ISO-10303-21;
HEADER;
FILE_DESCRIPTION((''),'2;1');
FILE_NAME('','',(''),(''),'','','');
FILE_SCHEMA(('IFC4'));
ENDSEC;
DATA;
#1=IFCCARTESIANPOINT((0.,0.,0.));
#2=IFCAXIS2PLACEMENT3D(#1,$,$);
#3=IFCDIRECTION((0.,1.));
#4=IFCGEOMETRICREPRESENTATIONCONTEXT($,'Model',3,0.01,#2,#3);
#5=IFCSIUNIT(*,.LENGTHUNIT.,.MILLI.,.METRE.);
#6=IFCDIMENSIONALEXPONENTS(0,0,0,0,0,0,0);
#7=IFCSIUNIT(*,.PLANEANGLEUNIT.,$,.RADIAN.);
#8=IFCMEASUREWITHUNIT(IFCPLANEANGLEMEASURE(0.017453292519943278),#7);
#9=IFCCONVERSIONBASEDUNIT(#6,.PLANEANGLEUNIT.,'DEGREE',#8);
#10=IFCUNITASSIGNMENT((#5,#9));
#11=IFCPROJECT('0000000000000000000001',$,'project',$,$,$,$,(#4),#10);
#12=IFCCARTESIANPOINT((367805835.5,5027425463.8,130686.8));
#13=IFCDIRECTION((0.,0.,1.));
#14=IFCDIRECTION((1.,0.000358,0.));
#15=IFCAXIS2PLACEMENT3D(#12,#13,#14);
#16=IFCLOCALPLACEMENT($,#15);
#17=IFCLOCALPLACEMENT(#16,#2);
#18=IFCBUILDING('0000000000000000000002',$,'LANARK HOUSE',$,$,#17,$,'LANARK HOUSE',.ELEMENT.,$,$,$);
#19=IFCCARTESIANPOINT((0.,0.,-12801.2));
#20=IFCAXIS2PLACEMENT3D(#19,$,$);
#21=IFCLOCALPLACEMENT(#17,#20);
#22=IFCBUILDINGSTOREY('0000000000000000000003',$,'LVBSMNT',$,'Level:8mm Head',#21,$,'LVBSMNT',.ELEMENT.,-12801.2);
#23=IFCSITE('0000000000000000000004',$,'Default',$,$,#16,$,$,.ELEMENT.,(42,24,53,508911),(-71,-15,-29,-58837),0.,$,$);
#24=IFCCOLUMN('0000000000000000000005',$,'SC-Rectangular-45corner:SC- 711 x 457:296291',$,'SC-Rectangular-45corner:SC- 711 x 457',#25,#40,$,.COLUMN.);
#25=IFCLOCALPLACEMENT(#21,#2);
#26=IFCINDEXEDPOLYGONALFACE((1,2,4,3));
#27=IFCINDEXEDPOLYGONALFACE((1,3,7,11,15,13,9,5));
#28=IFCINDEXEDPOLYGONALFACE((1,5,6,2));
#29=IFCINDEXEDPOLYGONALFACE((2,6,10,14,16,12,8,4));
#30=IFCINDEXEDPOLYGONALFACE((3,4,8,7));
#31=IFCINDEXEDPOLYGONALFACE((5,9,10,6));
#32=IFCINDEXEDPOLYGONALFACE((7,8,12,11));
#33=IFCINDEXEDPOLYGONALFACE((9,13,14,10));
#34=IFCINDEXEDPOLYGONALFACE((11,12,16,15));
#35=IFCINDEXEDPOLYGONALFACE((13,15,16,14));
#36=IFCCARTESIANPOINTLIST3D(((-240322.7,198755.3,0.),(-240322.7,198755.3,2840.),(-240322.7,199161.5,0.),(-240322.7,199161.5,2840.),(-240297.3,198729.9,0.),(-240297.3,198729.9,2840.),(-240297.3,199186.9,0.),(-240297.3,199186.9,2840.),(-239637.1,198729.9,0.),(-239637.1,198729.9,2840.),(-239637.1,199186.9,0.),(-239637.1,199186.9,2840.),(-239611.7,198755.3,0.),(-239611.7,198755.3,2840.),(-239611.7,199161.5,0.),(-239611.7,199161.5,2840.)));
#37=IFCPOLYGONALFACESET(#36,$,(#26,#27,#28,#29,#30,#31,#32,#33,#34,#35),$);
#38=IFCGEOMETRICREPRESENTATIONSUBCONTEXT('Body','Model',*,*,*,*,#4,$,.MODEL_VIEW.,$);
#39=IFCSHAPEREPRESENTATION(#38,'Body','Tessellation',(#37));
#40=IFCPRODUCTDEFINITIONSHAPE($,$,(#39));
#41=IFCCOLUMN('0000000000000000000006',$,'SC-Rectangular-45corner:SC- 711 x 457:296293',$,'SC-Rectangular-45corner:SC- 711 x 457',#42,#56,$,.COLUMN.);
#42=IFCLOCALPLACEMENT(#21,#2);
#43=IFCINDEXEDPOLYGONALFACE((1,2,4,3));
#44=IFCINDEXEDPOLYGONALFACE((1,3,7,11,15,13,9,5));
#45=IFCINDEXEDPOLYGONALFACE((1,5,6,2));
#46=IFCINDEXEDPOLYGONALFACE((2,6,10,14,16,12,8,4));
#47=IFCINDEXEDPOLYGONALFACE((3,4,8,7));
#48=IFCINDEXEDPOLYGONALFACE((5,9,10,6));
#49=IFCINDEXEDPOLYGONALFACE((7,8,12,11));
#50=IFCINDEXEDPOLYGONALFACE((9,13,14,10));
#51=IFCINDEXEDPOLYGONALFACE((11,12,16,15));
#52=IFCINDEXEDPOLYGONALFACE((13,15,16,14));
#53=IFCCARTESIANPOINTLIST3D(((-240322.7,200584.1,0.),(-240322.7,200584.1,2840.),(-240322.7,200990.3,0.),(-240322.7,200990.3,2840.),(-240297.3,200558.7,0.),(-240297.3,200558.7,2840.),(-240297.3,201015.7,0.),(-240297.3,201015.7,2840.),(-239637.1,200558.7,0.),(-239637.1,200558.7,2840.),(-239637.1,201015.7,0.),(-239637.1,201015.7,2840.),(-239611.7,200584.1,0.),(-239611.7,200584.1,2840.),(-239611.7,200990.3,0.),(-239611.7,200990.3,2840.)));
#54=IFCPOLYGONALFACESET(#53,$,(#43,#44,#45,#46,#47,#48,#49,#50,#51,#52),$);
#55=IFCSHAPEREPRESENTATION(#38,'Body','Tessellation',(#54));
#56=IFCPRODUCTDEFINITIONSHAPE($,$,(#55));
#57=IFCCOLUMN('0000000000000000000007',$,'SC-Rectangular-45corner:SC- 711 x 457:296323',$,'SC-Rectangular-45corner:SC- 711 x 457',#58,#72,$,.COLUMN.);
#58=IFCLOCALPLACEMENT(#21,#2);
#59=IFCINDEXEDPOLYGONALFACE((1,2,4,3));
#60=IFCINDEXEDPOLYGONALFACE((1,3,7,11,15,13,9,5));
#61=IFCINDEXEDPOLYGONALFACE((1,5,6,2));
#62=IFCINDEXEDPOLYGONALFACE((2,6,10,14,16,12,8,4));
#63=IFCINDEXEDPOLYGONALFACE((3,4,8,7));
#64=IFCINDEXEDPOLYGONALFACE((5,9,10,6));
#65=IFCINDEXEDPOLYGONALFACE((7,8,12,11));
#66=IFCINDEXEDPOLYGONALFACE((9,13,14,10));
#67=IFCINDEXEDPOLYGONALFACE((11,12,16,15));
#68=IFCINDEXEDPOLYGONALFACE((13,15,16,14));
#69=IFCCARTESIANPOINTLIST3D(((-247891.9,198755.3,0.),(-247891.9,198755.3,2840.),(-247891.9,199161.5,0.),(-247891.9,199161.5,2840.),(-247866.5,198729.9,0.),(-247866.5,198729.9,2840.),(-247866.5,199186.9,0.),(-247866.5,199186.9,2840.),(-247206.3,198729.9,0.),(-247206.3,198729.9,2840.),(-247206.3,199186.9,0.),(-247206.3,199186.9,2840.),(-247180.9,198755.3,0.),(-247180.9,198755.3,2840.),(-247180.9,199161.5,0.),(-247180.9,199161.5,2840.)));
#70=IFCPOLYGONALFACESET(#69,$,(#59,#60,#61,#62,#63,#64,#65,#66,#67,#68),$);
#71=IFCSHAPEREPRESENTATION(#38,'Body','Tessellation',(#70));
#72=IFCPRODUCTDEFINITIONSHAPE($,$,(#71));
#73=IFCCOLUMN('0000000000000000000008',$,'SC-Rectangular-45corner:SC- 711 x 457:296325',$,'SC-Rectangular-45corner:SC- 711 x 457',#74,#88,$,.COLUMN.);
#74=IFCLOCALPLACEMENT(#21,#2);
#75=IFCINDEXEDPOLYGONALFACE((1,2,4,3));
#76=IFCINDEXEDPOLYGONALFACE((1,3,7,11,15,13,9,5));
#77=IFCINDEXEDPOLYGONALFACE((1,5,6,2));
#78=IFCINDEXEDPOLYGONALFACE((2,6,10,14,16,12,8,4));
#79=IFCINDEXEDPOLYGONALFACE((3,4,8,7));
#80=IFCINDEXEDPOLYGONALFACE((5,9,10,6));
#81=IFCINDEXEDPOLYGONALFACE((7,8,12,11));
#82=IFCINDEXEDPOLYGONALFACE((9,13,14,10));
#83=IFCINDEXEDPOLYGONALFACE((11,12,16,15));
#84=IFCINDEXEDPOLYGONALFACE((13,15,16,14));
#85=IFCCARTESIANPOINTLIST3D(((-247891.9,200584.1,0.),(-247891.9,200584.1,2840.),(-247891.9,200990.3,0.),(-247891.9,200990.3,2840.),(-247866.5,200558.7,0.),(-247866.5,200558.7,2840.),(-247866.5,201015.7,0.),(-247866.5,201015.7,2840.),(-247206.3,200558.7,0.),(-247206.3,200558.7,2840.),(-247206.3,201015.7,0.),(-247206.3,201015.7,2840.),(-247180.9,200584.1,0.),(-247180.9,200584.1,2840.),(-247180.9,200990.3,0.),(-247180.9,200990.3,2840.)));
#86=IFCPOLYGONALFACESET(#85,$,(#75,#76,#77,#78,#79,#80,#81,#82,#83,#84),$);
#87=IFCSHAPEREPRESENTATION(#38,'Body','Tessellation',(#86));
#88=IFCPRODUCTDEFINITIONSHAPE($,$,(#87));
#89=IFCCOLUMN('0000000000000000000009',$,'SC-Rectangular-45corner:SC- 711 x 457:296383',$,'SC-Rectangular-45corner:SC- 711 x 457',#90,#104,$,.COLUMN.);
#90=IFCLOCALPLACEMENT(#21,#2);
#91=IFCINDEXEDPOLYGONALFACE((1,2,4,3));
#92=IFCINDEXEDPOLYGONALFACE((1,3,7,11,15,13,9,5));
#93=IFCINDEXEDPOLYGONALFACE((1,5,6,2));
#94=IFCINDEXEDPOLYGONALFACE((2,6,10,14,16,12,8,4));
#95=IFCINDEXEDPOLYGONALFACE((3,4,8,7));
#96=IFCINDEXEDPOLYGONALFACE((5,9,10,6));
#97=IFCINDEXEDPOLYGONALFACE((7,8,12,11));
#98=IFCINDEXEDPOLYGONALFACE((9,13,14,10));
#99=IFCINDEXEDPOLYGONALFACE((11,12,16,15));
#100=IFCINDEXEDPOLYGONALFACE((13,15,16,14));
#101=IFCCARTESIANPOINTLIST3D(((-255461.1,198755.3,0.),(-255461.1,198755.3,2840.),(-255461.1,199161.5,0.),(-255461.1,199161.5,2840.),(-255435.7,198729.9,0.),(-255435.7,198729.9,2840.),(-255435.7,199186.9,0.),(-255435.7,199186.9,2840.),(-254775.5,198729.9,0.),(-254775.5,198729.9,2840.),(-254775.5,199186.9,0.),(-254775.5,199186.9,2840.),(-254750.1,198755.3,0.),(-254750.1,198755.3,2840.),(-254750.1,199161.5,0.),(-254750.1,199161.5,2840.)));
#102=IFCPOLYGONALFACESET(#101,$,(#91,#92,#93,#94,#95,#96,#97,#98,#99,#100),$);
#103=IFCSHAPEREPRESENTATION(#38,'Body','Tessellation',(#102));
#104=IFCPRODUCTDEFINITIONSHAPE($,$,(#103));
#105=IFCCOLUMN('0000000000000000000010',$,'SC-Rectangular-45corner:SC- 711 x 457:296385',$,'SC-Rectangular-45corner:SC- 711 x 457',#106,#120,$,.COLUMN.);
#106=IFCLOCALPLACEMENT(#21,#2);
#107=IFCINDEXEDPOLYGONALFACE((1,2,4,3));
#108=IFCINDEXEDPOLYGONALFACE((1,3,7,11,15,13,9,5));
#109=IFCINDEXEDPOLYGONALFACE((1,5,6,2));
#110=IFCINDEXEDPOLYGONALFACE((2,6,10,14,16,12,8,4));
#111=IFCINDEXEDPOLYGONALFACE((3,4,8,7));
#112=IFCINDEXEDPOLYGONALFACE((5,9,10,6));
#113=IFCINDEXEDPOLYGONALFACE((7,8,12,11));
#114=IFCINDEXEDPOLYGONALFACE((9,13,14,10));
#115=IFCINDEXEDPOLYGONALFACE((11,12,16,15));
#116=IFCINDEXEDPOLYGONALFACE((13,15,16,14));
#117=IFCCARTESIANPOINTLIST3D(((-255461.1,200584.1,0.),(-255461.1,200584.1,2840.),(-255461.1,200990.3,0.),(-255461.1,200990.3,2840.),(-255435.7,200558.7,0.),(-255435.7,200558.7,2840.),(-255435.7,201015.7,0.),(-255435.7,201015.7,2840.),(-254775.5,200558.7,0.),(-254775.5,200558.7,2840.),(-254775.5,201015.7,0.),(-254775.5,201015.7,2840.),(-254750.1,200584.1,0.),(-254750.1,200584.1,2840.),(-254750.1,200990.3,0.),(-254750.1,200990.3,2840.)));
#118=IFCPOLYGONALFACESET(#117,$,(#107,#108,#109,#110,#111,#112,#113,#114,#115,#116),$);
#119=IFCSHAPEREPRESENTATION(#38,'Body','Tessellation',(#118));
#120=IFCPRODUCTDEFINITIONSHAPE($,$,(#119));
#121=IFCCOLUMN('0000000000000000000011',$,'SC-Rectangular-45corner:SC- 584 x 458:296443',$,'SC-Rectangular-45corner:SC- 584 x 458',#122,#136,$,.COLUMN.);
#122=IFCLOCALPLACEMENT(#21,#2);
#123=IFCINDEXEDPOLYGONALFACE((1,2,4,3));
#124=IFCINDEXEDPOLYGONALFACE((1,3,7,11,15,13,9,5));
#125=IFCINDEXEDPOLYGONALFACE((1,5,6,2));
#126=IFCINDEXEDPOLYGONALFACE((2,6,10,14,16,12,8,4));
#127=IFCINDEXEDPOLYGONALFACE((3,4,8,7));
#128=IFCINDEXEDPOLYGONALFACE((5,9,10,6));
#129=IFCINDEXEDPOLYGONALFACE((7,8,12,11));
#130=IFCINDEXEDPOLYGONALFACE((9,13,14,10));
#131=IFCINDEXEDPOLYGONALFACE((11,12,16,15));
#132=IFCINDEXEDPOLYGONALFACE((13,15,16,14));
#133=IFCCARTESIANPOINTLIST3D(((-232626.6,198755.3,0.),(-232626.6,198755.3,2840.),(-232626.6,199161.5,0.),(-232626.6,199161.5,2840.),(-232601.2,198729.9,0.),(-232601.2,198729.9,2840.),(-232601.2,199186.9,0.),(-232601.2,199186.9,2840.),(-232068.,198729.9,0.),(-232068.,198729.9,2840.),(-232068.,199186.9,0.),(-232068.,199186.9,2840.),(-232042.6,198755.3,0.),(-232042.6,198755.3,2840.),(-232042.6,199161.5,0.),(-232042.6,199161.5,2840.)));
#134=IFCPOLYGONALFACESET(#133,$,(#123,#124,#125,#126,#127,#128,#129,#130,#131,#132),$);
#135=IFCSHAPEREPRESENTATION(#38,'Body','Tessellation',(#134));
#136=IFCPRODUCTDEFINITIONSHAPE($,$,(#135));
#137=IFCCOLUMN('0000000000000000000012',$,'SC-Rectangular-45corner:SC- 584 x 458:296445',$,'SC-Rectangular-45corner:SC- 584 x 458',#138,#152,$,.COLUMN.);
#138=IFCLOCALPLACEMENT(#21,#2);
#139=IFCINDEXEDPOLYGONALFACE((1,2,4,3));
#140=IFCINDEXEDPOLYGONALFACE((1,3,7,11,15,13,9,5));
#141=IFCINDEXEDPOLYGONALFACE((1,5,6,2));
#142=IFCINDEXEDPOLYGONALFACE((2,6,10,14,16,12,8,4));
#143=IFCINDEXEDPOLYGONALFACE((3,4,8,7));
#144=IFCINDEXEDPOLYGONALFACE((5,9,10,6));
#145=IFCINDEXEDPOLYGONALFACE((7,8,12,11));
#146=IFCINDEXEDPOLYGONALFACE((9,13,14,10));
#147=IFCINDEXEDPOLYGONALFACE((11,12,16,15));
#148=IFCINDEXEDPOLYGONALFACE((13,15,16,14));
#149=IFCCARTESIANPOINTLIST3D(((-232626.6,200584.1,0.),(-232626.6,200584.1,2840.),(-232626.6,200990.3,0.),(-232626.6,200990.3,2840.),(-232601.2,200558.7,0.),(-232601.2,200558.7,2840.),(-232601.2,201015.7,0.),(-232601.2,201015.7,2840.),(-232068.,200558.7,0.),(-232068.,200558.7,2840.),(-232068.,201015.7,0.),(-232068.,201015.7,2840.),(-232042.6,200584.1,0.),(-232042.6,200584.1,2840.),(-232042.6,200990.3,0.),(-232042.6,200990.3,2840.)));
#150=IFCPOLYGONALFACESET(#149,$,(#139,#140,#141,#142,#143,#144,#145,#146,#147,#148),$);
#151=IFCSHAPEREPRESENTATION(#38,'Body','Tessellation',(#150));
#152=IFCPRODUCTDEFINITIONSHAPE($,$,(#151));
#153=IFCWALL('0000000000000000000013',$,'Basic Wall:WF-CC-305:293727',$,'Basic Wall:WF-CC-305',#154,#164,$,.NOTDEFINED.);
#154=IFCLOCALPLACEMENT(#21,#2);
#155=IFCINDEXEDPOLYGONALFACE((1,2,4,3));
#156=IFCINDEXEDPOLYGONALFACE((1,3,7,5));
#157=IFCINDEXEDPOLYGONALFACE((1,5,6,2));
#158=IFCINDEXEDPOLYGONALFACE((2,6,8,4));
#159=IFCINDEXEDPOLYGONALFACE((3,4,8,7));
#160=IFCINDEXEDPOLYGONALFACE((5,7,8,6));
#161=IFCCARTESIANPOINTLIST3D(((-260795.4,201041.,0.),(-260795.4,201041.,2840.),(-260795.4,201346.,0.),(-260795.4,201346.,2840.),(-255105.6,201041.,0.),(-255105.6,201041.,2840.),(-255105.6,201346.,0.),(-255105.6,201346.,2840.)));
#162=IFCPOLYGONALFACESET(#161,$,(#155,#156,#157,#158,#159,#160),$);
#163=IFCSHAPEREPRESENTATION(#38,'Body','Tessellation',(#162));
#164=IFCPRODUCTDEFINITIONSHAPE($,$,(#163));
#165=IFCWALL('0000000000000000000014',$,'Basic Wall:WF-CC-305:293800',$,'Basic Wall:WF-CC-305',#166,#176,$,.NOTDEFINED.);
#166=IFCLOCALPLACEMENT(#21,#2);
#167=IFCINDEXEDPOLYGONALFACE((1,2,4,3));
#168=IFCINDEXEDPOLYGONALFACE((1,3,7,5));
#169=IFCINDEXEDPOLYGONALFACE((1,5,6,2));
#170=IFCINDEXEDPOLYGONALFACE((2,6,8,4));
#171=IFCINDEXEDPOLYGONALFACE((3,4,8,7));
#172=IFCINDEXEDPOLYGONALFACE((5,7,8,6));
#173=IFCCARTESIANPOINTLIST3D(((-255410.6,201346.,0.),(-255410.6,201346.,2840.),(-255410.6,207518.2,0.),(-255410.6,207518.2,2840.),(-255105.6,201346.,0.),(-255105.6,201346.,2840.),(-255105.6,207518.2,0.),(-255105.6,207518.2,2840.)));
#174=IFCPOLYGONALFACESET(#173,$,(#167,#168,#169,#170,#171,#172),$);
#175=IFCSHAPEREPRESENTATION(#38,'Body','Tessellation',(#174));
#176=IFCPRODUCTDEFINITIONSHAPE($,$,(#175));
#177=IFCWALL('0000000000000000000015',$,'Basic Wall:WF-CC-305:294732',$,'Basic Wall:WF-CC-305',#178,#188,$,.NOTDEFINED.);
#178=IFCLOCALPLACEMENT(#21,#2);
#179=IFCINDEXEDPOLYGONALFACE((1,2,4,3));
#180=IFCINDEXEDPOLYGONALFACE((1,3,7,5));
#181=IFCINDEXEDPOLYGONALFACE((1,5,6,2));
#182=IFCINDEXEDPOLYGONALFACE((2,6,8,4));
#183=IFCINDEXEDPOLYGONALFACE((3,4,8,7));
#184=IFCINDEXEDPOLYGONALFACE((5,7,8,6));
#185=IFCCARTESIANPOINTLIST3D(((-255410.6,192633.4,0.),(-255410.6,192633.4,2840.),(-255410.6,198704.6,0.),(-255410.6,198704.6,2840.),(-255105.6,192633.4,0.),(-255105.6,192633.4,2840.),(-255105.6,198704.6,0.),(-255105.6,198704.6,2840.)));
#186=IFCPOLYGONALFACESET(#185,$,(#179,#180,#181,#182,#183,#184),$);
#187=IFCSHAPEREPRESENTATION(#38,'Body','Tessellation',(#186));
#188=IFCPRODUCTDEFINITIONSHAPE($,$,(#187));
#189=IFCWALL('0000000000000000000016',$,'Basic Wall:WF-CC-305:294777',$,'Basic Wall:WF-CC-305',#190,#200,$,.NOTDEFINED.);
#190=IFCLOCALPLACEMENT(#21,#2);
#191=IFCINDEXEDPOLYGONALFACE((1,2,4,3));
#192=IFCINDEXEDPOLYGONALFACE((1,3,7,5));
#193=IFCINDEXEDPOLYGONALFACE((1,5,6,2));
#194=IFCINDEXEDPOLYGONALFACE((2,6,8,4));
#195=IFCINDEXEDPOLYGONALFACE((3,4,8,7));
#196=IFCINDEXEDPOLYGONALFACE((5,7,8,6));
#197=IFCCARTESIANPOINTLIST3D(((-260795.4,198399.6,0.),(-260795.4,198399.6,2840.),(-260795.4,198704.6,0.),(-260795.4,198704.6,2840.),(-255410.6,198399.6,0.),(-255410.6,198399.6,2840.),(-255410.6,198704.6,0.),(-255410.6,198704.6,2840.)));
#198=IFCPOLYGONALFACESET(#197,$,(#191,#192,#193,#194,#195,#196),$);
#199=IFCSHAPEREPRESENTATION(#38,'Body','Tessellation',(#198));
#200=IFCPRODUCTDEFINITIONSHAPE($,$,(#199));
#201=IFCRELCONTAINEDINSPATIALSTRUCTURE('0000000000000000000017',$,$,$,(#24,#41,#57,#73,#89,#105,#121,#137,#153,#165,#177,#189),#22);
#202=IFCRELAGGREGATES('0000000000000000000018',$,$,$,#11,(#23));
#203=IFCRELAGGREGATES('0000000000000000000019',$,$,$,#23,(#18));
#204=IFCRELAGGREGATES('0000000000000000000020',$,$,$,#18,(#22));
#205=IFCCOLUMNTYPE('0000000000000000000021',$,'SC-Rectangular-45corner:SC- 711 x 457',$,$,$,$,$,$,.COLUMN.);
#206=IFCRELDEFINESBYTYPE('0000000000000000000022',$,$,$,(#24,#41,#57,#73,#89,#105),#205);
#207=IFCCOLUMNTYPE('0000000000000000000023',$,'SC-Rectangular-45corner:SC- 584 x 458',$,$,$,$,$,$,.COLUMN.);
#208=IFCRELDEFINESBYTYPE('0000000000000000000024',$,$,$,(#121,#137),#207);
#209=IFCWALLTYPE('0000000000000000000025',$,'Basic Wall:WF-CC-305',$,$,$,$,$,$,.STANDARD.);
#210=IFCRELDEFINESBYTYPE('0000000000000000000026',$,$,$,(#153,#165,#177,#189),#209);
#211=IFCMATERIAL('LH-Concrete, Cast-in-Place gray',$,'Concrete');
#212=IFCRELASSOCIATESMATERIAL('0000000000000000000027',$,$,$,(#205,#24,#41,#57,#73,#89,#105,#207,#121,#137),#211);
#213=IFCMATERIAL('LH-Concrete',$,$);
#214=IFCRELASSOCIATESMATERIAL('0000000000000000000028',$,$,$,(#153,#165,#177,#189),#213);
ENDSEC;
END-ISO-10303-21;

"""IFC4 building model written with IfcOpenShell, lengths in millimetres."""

from ifc_helpers import new_model, entity, si_unit, converted_unit, direction, frame, origin, place, context, subcontext, project, spatial, indexed_curve, outline, extrude, source, transform, mapped, material, type_object, type_shapes, element, save


model = new_model("IFC4")

# Units and contexts
model_context = context("Model", 3, precision=0.01, world=origin(), true_north=direction((0.0, 1.0)))
body_context = subcontext(model_context, "Body", "Model", "MODEL_VIEW")
ifc_project = project(units=[si_unit("LENGTHUNIT", "METRE", prefix="MILLI"), converted_unit("PLANEANGLEUNIT", "DEGREE", entity("IfcPlaneAngleMeasure", 0.017453292519943278), si_unit("PLANEANGLEUNIT", "RADIAN"), dimensions=[0, 0, 0, 0, 0, 0, 0])], contexts=[model_context])

# Site, building, storey
site_placement = place(None, frame((367805835.5, 5027425463.8, 130686.8), z_axis=(0.0, 0.0, 1.0), x_axis=(1.0, 0.000358, 0.0)))
site = spatial("IfcSite", under=ifc_project, at=site_placement, Name="Default", CompositionType="ELEMENT", RefLatitude=(42, 24, 53, 508911), RefLongitude=(-71, -15, -29, -58837), RefElevation=0.0)
building_placement = place(site_placement, origin())
building = spatial("IfcBuilding", under=site, at=building_placement, Name="LANARK HOUSE", LongName="LANARK HOUSE", CompositionType="ELEMENT")
storey_placement = place(building_placement, frame((0.0, 0.0, -12801.2)))
storey = spatial("IfcBuildingStorey", under=building, at=storey_placement, Name="LVBSMNT", ObjectType="Level:8mm Head", LongName="LVBSMNT", CompositionType="ELEMENT", Elevation=-12801.2)

# Columns
ifc_material_1 = material(Name="LH-Concrete, Cast-in-Place gray", Category="Concrete")
column_type_1 = type_object("IfcColumnType", Name="SC-Rectangular-45corner:SC- 711 x 457", PredefinedType="COLUMN", material=ifc_material_1)
shared_shape_1 = source(origin(), body_context, "Body", "SweptSolid", [
    extrude(outline(indexed_curve([(-330.1, -228.5), (330.1, -228.5), (355.5, -203.1), (355.5, 203.1), (330.1, 228.5), (-330.1, 228.5), (-355.5, 203.1), (-355.5, -203.1), (-330.1, -228.5)], self_intersect=False)), frame((0.0, 0.0, -12801.2), z_axis=(0.0, 0.0, 1.0), x_axis=(-1.0, 0.0, 0.0)), (0.0, 0.0, 1.0), 2840.0),
])
type_shapes(column_type_1, [shared_shape_1])
for number, where, name in (
    (1, (-239967.2, 198958.4, 12801.2), "SC-Rectangular-45corner:SC- 711 x 457:296291"),
    (2, (-239967.2, 200787.2, 12801.2), "SC-Rectangular-45corner:SC- 711 x 457:296293"),
    (3, (-247536.4, 198958.4, 12801.2), "SC-Rectangular-45corner:SC- 711 x 457:296323"),
    (4, (-247536.4, 200787.2, 12801.2), "SC-Rectangular-45corner:SC- 711 x 457:296325"),
    (5, (-255105.6, 198958.4, 12801.2), "SC-Rectangular-45corner:SC- 711 x 457:296383"),
    (6, (-255105.6, 200787.2, 12801.2), "SC-Rectangular-45corner:SC- 711 x 457:296385"),
):
    element("IfcColumn", number, at=place(storey_placement, frame(where)), inside=storey, type_object=column_type_1, material=ifc_material_1, Name=name, ObjectType="SC-Rectangular-45corner:SC- 711 x 457", PredefinedType="COLUMN", context=body_context, shape_type="MappedRepresentation", body=[
        mapped(shared_shape_1, transform((0.0, 0.0, 0.0), scale=1.0)),
    ])
column_type_2 = type_object("IfcColumnType", Name="SC-Rectangular-45corner:SC- 584 x 458", PredefinedType="COLUMN", material=ifc_material_1)
shared_shape_2 = source(origin(), body_context, "Body", "SweptSolid", [
    extrude(outline(indexed_curve([(-266.6, -228.5), (266.6, -228.5), (292.0, -203.1), (292.0, 203.1), (266.6, 228.5), (-266.6, 228.5), (-292.0, 203.1), (-292.0, -203.1), (-266.6, -228.5)], self_intersect=False)), frame((0.0, 0.0, -12801.2), z_axis=(0.0, 0.0, 1.0), x_axis=(-1.0, 0.0, 0.0)), (0.0, 0.0, 1.0), 2840.0),
])
type_shapes(column_type_2, [shared_shape_2])
for number, where, name in (
    (7, (-232334.6, 198958.4, 12801.2), "SC-Rectangular-45corner:SC- 584 x 458:296443"),
    (8, (-232334.6, 200787.2, 12801.2), "SC-Rectangular-45corner:SC- 584 x 458:296445"),
):
    element("IfcColumn", number, at=place(storey_placement, frame(where)), inside=storey, type_object=column_type_2, material=ifc_material_1, Name=name, ObjectType="SC-Rectangular-45corner:SC- 584 x 458", PredefinedType="COLUMN", context=body_context, shape_type="MappedRepresentation", body=[
        mapped(shared_shape_2, transform((0.0, 0.0, 0.0), scale=1.0)),
    ])

# Walls
ifc_material_2 = material(Name="LH-Concrete")
wall_type_1 = type_object("IfcWallType", Name="Basic Wall:WF-CC-305", PredefinedType="STANDARD")
wall_1_placement = place(storey_placement, frame((-260795.4, 201193.5, 0.0)))
element("IfcWall", 9, at=wall_1_placement, inside=storey, type_object=wall_type_1, material=ifc_material_2, Name="Basic Wall:WF-CC-305:293727", ObjectType="Basic Wall:WF-CC-305", PredefinedType="NOTDEFINED", context=body_context, shape_type="SweptSolid", body=[
    extrude(outline(indexed_curve([(5689.8, 152.5), (0.0, 152.5), (0.0, -152.5), (5689.8, -152.5), (5689.8, 152.5)], self_intersect=False)), origin(), (0.0, 0.0, 1.0), 2840.0),
])
wall_2_placement = place(storey_placement, frame((-255258.1, 201346.0, 0.0), z_axis=(0.0, 0.0, 1.0), x_axis=(0.0, 1.0, 0.0)))
element("IfcWall", 10, at=wall_2_placement, inside=storey, type_object=wall_type_1, material=ifc_material_2, Name="Basic Wall:WF-CC-305:293800", ObjectType="Basic Wall:WF-CC-305", PredefinedType="NOTDEFINED", context=body_context, shape_type="SweptSolid", body=[
    extrude(outline(indexed_curve([(6172.2, 152.5), (0.0, 152.5), (0.0, -152.5), (6172.2, -152.5), (6172.2, 152.5)], self_intersect=False)), origin(), (0.0, 0.0, 1.0), 2840.0),
])
wall_3_placement = place(storey_placement, frame((-255258.1, 192633.4, 0.0), z_axis=(0.0, 0.0, 1.0), x_axis=(0.0, 1.0, 0.0)))
element("IfcWall", 11, at=wall_3_placement, inside=storey, type_object=wall_type_1, material=ifc_material_2, Name="Basic Wall:WF-CC-305:294732", ObjectType="Basic Wall:WF-CC-305", PredefinedType="NOTDEFINED", context=body_context, shape_type="SweptSolid", body=[
    extrude(outline(indexed_curve([(6071.2, 152.5), (0.0, 152.5), (0.0, -152.5), (6071.2, -152.5), (6071.2, 152.5)], self_intersect=False)), origin(), (0.0, 0.0, 1.0), 2840.0),
])
wall_4_placement = place(storey_placement, frame((-255410.6, 198552.1, 0.0), z_axis=(0.0, 0.0, 1.0), x_axis=(-1.0, 0.0, 0.0)))
element("IfcWall", 12, at=wall_4_placement, inside=storey, type_object=wall_type_1, material=ifc_material_2, Name="Basic Wall:WF-CC-305:294777", ObjectType="Basic Wall:WF-CC-305", PredefinedType="NOTDEFINED", context=body_context, shape_type="SweptSolid", body=[
    extrude(outline(indexed_curve([(5384.8, 152.5), (0.0, 152.5), (0.0, -152.5), (5384.8, -152.5), (5384.8, 152.5)], self_intersect=False)), origin(), (0.0, 0.0, 1.0), 2840.0),
])

save(model, "model.ifc")
